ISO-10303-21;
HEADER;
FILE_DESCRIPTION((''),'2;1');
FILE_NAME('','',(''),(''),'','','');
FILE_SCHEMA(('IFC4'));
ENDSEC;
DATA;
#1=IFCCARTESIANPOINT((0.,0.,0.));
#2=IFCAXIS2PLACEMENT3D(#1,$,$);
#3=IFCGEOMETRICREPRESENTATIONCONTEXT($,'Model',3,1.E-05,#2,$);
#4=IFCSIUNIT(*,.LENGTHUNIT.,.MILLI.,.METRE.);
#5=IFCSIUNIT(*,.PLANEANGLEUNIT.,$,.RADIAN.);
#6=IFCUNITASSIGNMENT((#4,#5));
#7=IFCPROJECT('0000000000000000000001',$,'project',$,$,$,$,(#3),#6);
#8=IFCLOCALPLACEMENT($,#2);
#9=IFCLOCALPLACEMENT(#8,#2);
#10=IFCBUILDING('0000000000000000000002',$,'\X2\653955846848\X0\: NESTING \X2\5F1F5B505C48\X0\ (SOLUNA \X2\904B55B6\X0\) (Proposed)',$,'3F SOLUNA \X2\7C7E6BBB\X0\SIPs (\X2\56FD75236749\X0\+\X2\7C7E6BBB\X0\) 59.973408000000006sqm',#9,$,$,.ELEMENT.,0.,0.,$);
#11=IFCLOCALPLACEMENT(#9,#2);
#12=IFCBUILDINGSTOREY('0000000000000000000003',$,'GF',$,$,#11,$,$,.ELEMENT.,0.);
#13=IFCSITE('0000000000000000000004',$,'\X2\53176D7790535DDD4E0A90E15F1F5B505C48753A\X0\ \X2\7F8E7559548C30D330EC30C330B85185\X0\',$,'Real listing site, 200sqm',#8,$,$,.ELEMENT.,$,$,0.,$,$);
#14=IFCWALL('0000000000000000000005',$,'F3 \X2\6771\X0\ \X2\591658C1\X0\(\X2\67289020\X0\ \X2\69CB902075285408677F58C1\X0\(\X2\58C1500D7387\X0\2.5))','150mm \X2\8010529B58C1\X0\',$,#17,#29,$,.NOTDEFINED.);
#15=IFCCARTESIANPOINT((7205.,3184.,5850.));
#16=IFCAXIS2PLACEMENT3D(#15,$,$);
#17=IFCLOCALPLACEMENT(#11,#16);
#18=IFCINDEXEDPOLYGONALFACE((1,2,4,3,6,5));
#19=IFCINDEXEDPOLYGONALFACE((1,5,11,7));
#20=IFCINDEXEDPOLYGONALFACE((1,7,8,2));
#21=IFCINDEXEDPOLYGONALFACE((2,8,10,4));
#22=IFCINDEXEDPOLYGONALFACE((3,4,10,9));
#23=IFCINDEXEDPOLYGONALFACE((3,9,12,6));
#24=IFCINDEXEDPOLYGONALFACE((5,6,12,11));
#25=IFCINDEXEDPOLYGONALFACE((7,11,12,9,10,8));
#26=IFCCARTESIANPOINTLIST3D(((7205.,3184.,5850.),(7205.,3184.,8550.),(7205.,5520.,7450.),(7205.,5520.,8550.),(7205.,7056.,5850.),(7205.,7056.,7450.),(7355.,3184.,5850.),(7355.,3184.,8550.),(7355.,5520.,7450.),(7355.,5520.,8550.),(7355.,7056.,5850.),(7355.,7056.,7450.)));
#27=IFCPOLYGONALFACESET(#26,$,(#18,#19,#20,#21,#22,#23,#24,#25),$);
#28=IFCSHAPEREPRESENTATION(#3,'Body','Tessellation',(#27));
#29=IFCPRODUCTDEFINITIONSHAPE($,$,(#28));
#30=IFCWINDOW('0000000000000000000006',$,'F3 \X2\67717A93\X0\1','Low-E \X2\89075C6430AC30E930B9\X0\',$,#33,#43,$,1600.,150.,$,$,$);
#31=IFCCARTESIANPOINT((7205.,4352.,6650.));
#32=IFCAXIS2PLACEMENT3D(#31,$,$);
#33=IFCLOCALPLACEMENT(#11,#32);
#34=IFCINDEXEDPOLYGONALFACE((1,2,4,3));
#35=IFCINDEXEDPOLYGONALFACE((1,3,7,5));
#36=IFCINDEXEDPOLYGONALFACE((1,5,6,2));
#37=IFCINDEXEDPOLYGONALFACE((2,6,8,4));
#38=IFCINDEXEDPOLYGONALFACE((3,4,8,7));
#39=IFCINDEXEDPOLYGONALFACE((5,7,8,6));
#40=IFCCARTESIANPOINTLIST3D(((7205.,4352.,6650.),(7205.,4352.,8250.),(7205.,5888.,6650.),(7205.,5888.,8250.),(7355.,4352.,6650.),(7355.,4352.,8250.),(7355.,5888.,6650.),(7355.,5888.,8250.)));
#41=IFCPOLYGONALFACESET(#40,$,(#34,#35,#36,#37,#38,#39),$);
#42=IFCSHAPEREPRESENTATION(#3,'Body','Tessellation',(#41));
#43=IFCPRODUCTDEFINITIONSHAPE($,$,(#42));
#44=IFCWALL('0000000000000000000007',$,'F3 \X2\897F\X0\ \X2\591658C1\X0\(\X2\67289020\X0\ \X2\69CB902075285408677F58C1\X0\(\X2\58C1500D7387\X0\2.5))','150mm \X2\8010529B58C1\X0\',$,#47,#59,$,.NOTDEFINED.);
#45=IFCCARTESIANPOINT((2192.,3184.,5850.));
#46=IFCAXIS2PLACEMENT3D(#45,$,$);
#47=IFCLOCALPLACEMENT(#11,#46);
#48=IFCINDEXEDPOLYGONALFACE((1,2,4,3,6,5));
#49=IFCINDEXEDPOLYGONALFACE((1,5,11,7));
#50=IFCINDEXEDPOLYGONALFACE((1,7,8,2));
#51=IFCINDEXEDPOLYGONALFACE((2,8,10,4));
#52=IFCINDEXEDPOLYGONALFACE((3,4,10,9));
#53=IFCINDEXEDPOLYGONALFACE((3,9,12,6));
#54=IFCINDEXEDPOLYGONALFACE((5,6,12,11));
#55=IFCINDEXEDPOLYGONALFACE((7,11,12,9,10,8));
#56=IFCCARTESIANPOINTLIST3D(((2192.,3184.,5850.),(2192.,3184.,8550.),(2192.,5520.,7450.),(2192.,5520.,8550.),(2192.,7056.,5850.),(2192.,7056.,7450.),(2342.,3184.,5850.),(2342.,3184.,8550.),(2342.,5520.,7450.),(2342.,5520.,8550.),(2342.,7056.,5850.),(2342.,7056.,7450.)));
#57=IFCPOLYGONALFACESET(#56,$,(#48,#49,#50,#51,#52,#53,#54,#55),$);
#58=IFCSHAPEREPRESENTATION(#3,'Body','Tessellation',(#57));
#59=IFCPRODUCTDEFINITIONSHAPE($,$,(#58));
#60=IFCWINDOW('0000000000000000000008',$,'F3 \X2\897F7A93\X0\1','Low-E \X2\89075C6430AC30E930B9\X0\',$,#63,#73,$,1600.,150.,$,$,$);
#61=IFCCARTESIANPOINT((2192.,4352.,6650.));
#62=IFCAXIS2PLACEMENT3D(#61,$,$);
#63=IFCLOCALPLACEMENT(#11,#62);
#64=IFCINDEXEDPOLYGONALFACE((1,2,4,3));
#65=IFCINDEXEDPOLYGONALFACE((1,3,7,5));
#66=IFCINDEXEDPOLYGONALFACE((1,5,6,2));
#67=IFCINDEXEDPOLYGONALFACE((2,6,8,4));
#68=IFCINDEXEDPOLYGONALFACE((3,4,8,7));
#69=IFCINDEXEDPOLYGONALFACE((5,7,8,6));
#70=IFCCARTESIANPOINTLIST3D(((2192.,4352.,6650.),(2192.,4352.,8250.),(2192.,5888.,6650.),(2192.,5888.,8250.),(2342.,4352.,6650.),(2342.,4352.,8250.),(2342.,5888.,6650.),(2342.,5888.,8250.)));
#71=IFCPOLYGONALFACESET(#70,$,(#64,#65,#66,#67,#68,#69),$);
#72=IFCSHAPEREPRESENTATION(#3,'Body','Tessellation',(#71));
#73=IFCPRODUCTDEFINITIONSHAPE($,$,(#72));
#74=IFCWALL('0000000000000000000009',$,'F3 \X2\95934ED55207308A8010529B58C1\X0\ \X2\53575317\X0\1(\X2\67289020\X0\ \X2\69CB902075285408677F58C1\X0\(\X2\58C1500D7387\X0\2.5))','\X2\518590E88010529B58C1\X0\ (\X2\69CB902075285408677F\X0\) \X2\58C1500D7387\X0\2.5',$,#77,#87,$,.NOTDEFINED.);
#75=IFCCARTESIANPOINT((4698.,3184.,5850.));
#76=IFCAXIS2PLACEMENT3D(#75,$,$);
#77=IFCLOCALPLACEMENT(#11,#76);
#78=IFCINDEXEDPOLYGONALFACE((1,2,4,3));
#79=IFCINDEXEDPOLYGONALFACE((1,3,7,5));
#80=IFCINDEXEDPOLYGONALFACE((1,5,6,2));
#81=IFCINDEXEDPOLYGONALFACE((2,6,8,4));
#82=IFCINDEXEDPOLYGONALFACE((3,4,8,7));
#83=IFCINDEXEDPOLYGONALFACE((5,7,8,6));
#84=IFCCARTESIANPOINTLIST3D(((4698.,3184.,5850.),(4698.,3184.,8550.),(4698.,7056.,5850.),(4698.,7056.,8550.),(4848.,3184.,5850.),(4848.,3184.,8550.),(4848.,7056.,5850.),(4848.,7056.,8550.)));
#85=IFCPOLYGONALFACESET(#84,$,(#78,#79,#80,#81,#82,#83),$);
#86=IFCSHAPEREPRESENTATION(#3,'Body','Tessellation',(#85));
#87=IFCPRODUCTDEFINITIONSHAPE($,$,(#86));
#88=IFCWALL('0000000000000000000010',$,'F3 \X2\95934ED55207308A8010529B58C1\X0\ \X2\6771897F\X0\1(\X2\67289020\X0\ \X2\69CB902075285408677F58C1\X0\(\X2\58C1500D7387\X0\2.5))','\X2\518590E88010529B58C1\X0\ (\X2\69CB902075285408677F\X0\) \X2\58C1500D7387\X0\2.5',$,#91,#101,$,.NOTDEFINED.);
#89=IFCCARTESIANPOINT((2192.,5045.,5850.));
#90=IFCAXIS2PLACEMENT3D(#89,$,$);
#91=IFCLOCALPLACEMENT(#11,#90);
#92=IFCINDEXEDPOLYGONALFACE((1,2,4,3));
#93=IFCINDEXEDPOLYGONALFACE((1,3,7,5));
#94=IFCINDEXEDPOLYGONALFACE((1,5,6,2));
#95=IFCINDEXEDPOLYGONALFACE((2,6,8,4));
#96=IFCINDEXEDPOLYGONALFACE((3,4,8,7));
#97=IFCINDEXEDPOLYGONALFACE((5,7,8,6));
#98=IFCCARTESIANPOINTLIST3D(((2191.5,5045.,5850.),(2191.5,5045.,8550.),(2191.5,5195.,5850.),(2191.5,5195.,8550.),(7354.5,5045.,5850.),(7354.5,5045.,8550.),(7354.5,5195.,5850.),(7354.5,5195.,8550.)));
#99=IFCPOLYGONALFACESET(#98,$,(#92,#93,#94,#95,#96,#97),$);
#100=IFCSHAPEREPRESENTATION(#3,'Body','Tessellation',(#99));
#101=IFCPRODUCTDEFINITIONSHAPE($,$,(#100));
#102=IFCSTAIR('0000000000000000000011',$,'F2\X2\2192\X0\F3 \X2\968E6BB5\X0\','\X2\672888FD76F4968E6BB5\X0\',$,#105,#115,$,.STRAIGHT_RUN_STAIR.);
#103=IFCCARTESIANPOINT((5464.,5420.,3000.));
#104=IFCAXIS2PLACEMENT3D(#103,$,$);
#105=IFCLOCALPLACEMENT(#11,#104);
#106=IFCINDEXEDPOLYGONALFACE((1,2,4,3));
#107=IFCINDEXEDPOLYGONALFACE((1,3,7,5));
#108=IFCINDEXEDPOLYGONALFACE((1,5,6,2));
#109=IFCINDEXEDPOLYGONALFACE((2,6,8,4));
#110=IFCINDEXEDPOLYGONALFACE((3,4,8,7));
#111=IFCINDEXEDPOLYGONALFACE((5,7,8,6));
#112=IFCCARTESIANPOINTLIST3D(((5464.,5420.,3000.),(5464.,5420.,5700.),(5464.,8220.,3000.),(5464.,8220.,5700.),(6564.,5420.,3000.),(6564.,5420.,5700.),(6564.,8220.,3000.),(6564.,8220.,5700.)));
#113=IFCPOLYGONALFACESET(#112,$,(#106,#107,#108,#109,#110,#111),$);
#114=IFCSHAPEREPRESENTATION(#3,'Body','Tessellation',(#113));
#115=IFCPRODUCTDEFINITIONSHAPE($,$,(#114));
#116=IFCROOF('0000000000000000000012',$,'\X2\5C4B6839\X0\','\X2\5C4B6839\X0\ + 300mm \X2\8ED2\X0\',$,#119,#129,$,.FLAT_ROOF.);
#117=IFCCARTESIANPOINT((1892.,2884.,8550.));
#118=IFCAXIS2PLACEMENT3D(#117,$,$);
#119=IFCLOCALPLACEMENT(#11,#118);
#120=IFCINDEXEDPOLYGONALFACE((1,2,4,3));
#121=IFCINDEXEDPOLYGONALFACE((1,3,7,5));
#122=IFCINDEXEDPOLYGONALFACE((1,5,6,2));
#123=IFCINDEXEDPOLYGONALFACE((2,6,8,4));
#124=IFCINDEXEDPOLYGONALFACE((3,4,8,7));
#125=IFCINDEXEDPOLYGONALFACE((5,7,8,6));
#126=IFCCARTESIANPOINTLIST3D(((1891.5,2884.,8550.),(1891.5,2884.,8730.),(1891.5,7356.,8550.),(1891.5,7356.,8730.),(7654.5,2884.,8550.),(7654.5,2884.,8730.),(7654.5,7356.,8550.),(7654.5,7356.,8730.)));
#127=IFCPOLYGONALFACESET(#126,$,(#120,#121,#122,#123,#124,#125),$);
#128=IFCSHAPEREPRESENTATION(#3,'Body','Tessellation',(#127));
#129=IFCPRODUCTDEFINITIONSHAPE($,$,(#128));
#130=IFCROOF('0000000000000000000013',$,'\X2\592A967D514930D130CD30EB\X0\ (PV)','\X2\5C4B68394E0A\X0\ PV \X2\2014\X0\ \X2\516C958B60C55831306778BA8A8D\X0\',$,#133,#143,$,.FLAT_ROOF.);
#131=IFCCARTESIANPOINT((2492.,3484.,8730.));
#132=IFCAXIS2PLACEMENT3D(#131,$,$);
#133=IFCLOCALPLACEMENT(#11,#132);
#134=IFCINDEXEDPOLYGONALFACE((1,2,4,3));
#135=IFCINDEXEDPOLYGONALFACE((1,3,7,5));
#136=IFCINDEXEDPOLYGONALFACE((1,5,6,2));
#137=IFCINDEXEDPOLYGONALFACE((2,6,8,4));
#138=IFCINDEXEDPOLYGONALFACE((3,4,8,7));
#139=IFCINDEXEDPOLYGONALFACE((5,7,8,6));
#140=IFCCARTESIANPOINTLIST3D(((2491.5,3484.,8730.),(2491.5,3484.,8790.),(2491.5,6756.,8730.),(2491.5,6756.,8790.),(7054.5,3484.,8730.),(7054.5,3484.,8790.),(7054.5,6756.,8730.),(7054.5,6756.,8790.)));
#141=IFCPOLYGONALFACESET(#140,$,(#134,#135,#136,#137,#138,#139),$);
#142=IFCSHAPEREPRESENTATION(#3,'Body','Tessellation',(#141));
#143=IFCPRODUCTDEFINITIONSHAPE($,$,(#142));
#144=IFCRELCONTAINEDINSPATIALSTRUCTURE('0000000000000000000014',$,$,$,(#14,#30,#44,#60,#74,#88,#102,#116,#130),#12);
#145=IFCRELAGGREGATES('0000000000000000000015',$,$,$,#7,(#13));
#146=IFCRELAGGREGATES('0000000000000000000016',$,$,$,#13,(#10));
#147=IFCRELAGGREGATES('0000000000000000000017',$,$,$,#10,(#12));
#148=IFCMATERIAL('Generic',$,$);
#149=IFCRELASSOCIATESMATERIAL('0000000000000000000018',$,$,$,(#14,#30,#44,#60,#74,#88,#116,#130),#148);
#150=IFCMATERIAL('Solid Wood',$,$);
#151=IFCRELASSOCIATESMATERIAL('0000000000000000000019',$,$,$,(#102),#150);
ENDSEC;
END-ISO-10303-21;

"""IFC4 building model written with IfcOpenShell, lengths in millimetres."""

from ifc_helpers import new_model, si_unit, frame, frame_2d, origin, place, context, project, spatial, rectangle, extrude, material, element, fill, save


model = new_model("IFC4")

# Units and contexts
model_context = context("Model", 3, precision=1e-05, world=origin())
ifc_project = project(units=[si_unit("LENGTHUNIT", "METRE", prefix="MILLI"), si_unit("PLANEANGLEUNIT", "RADIAN")], contexts=[model_context])

# Site, building, storey
site_placement = place(None, origin())
site = spatial("IfcSite", under=ifc_project, at=site_placement, Name="北海道川上郡弟子屈町 美留和ビレッジ内", ObjectType="Real listing site, 200sqm", CompositionType="ELEMENT", RefElevation=0.0)
building_placement = place(site_placement, origin())
building = spatial("IfcBuilding", under=site, at=building_placement, Name="改善案: NESTING 弟子屈 (SOLUNA 運営) (Proposed)", ObjectType="3F SOLUNA 籾殻SIPs (国産杉+籾殻) 59.973408000000006sqm", CompositionType="ELEMENT", ElevationOfRefHeight=0.0, ElevationOfTerrain=0.0)
storey_placement = place(building_placement, origin())
storey = spatial("IfcBuildingStorey", under=building, at=storey_placement, Name="GF", CompositionType="ELEMENT", Elevation=0.0)

# Shared definitions
ifc_material_1 = material(Name="Generic")

# Walls, openings, windows
wall_1_placement = place(storey_placement, frame((7205.0, 3184.0, 5850.0)))
wall_1 = element("IfcWall", 1, at=wall_1_placement, inside=storey, material=ifc_material_1, Name="F3 東 外壁(木造 構造用合板壁(壁倍率2.5))", Description="150mm 耐力壁", PredefinedType="NOTDEFINED", context=model_context, shape_type="SweptSolid", body=[
    extrude(rectangle(XDim=150.0, YDim=3872.0, at=frame_2d((75.0, 1936.0))), frame((7205.0, 3184.0, 5850.0)), (0.0, 0.0, 1.0), 2700.0),
])
opening_1_placement = place(storey_placement, frame((7205.0, 4352.0, 6650.0)))
opening_1 = element("IfcOpeningElement", 2, at=opening_1_placement, cuts=wall_1, PredefinedType="NOTDEFINED", context=model_context, shape_type="SweptSolid", body=[
    extrude(rectangle(XDim=150.0, YDim=1536.0, at=frame_2d((75.0, 768.0))), frame((7205.0, 4352.0, 6650.0)), (0.0, 0.0, 1.0), 1600.0),
])
window_1_placement = place(storey_placement, frame((7205.0, 4352.0, 6650.0)))
window_1 = element("IfcWindow", 3, at=window_1_placement, inside=storey, material=ifc_material_1, Name="F3 東窓1", Description="Low-E 複層ガラス", OverallHeight=1600.0, OverallWidth=150.0, context=model_context, shape_type="SweptSolid", body=[
    extrude(rectangle(XDim=150.0, YDim=1536.0, at=frame_2d((75.0, 768.0))), frame((7205.0, 4352.0, 6650.0)), (0.0, 0.0, 1.0), 1600.0),
])
fill(opening_1, window_1)
wall_2_placement = place(storey_placement, frame((2192.0, 3184.0, 5850.0)))
wall_2 = element("IfcWall", 4, at=wall_2_placement, inside=storey, material=ifc_material_1, Name="F3 西 外壁(木造 構造用合板壁(壁倍率2.5))", Description="150mm 耐力壁", PredefinedType="NOTDEFINED", context=model_context, shape_type="SweptSolid", body=[
    extrude(rectangle(XDim=150.0, YDim=3872.0, at=frame_2d((75.0, 1936.0))), frame((2192.0, 3184.0, 5850.0)), (0.0, 0.0, 1.0), 2700.0),
])
opening_2_placement = place(storey_placement, frame((2192.0, 4352.0, 6650.0)))
opening_2 = element("IfcOpeningElement", 5, at=opening_2_placement, cuts=wall_2, PredefinedType="NOTDEFINED", context=model_context, shape_type="SweptSolid", body=[
    extrude(rectangle(XDim=150.0, YDim=1536.0, at=frame_2d((75.0, 768.0))), frame((2192.0, 4352.0, 6650.0)), (0.0, 0.0, 1.0), 1600.0),
])
window_2_placement = place(storey_placement, frame((2192.0, 4352.0, 6650.0)))
window_2 = element("IfcWindow", 6, at=window_2_placement, inside=storey, material=ifc_material_1, Name="F3 西窓1", Description="Low-E 複層ガラス", OverallHeight=1600.0, OverallWidth=150.0, context=model_context, shape_type="SweptSolid", body=[
    extrude(rectangle(XDim=150.0, YDim=1536.0, at=frame_2d((75.0, 768.0))), frame((2192.0, 4352.0, 6650.0)), (0.0, 0.0, 1.0), 1600.0),
])
fill(opening_2, window_2)

# Walls
wall_3_placement = place(storey_placement, frame((4698.0, 3184.0, 5850.0)))
element("IfcWall", 7, at=wall_3_placement, inside=storey, material=ifc_material_1, Name="F3 間仕切り耐力壁 南北1(木造 構造用合板壁(壁倍率2.5))", Description="内部耐力壁 (構造用合板) 壁倍率2.5", PredefinedType="NOTDEFINED", context=model_context, shape_type="SweptSolid", body=[
    extrude(rectangle(XDim=150.0, YDim=3872.0, at=frame_2d((75.0, 1936.0))), frame((4698.0, 3184.0, 5850.0)), (0.0, 0.0, 1.0), 2700.0),
])
wall_4_placement = place(storey_placement, frame((2192.0, 5045.0, 5850.0)))
element("IfcWall", 8, at=wall_4_placement, inside=storey, material=ifc_material_1, Name="F3 間仕切り耐力壁 東西1(木造 構造用合板壁(壁倍率2.5))", Description="内部耐力壁 (構造用合板) 壁倍率2.5", PredefinedType="NOTDEFINED", context=model_context, shape_type="SweptSolid", body=[
    extrude(rectangle(XDim=5163.0, YDim=150.0, at=frame_2d((2581.0, 75.0))), frame((2192.0, 5045.0, 5850.0)), (0.0, 0.0, 1.0), 2700.0),
])

# Stair
ifc_material_2 = material(Name="Solid Wood")
stair_placement = place(storey_placement, frame((5464.0, 5420.0, 3000.0)))
element("IfcStair", 9, at=stair_placement, inside=storey, material=ifc_material_2, Name="F2→F3 階段", Description="木製直階段", PredefinedType="STRAIGHT_RUN_STAIR", context=model_context, shape_type="SweptSolid", body=[
    extrude(rectangle(XDim=1100.0, YDim=2800.0, at=frame_2d((550.0, 1400.0))), frame((5464.0, 5420.0, 3000.0)), (0.0, 0.0, 1.0), 2700.0),
])

# Roofs
roof_1_placement = place(storey_placement, frame((1892.0, 2884.0, 8550.0)))
element("IfcRoof", 10, at=roof_1_placement, inside=storey, material=ifc_material_1, Name="屋根", Description="屋根 + 300mm 軒", PredefinedType="FLAT_ROOF", context=model_context, shape_type="SweptSolid", body=[
    extrude(rectangle(XDim=5763.0, YDim=4472.0, at=frame_2d((2881.0, 2236.0))), frame((1892.0, 2884.0, 8550.0)), (0.0, 0.0, 1.0), 180.0),
])
roof_2_placement = place(storey_placement, frame((2492.0, 3484.0, 8730.0)))
element("IfcRoof", 11, at=roof_2_placement, inside=storey, material=ifc_material_1, Name="太陽光パネル (PV)", Description="屋根上 PV — 公開情報で確認", PredefinedType="FLAT_ROOF", context=model_context, shape_type="SweptSolid", body=[
    extrude(rectangle(XDim=4563.0, YDim=3272.0, at=frame_2d((2281.0, 1636.0))), frame((2492.0, 3484.0, 8730.0)), (0.0, 0.0, 1.0), 60.0),
])

save(model, "model.ifc")
